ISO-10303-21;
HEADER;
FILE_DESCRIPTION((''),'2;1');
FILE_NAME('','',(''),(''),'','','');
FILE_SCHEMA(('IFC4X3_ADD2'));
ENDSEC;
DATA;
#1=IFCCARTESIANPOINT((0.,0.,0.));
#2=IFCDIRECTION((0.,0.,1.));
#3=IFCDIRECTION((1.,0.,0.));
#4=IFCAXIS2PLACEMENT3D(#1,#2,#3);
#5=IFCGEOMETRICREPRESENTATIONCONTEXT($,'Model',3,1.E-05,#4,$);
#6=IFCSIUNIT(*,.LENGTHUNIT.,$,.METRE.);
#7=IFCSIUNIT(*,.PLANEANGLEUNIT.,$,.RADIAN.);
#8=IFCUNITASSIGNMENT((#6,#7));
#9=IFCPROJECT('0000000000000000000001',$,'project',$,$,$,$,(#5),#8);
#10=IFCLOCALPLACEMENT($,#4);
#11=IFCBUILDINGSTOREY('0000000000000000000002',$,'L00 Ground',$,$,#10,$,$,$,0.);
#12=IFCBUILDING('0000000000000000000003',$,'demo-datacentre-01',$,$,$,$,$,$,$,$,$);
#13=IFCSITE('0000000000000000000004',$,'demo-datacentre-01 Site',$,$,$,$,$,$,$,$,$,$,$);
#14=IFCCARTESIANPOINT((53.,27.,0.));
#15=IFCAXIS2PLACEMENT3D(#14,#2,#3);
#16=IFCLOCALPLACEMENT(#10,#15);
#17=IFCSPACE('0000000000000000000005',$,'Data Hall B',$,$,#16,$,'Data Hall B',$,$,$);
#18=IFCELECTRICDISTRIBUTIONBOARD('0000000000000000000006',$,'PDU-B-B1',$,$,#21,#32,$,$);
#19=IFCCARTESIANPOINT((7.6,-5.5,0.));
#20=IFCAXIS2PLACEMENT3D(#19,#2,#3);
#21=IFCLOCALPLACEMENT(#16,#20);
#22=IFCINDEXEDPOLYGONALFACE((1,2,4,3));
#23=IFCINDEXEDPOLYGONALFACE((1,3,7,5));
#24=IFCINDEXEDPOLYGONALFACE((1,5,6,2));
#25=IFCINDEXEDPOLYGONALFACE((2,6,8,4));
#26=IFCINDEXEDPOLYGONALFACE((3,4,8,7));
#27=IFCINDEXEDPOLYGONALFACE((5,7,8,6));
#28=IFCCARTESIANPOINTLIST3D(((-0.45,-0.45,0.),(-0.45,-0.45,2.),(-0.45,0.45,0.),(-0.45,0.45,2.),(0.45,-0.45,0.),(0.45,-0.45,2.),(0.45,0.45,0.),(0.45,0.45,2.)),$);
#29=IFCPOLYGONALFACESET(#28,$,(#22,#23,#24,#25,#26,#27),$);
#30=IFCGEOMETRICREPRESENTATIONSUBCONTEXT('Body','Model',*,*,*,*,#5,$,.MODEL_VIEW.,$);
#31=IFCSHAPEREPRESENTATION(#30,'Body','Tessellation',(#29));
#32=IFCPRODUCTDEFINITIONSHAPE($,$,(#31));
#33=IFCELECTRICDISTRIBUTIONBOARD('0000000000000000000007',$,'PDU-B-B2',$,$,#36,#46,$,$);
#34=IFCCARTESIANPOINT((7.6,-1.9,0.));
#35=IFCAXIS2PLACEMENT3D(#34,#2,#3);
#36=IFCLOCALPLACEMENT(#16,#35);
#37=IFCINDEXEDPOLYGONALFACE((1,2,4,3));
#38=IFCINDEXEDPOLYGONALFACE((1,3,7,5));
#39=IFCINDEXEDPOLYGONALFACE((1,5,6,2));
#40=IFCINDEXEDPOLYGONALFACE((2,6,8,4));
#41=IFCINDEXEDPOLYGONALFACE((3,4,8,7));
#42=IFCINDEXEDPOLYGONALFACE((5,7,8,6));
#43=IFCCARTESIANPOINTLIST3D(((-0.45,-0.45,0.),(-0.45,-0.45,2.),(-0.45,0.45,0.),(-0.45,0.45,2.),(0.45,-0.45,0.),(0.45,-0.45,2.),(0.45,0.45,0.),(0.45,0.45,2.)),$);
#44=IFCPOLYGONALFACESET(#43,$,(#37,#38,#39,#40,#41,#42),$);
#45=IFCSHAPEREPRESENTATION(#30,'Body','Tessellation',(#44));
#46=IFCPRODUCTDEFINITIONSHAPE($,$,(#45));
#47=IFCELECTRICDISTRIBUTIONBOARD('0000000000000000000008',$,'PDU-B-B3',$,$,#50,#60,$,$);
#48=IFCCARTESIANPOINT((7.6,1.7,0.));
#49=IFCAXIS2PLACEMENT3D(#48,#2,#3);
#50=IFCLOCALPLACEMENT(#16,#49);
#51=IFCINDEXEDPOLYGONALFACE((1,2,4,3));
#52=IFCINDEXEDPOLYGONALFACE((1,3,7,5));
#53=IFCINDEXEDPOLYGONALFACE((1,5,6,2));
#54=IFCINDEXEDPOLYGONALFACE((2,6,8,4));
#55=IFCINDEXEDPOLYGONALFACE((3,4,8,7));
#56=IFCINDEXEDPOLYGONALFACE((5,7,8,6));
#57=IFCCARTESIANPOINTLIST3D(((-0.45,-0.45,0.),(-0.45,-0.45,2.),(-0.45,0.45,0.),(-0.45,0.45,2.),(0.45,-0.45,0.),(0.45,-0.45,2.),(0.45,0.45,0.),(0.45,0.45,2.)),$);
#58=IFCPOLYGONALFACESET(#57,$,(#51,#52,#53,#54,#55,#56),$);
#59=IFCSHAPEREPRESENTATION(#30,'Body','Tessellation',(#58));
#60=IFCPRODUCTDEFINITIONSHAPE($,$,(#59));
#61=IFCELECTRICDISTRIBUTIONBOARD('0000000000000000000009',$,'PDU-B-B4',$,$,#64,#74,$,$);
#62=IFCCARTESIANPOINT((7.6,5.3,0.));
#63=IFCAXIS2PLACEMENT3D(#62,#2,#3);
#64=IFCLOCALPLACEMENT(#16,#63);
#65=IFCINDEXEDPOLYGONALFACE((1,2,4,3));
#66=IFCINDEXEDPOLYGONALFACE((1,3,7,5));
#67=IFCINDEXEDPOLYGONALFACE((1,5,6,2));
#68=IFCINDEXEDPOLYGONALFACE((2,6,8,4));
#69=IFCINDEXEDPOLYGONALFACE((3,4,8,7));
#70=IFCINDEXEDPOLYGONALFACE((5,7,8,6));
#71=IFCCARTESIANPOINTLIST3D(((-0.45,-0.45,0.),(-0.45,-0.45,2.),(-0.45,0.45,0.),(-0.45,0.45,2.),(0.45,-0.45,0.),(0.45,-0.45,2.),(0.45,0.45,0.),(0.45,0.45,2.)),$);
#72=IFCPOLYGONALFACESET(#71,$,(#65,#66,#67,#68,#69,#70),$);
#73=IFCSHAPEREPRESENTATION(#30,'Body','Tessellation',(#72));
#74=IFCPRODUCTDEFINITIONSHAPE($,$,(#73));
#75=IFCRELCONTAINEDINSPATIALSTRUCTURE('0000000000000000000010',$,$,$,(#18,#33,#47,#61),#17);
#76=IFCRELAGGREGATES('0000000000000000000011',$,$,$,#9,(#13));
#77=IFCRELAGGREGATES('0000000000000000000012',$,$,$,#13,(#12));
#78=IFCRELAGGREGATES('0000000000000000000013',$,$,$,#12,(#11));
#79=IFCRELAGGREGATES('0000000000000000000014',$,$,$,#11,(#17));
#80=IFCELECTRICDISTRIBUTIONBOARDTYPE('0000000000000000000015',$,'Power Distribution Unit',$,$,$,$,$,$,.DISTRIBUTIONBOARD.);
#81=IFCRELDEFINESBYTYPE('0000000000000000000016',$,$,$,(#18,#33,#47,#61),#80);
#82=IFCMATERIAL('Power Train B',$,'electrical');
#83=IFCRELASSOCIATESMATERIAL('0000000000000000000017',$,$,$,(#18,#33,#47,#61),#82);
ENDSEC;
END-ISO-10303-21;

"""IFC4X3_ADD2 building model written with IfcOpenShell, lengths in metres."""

from ifc_helpers import new_model, si_unit, frame, origin_with_axes, place, context, subcontext, project, spatial, rectangle, extrude, material, type_object, element, save


model = new_model("IFC4X3_ADD2")

# Units and contexts
model_context = context("Model", 3, precision=1e-05, world=origin_with_axes())
body_context = subcontext(model_context, "Body", "Model", "MODEL_VIEW")
ifc_project = project(units=[si_unit("LENGTHUNIT", "METRE"), si_unit("PLANEANGLEUNIT", "RADIAN")], contexts=[model_context])

# Site, building, storey, space
site = spatial("IfcSite", under=ifc_project, Name="demo-datacentre-01 Site")
building = spatial("IfcBuilding", under=site, Name="demo-datacentre-01")
storey_placement = place(None, origin_with_axes())
storey = spatial("IfcBuildingStorey", under=building, at=storey_placement, Name="L00 Ground", Elevation=0.0)
space_1_placement = place(storey_placement, frame((53.0, 27.0, 0.0), z_axis=(0.0, 0.0, 1.0), x_axis=(1.0, 0.0, 0.0)))
space_1 = spatial("IfcSpace", under=storey, at=space_1_placement, Name="Data Hall B", LongName="Data Hall B")

# Electric distribution boards
ifc_material = material(Name="Power Train B", Category="electrical")
electric_distribution_board_type_1 = type_object("IfcElectricDistributionBoardType", Name="Power Distribution Unit", PredefinedType="DISTRIBUTIONBOARD")
for number, where, z_axis, x_axis, name in (
    (1, (7.6, -5.5, 0.0), (0.0, 0.0, 1.0), (1.0, 0.0, 0.0), "PDU-B-B1"),
    (2, (7.6, -1.9, 0.0), (0.0, 0.0, 1.0), (1.0, 0.0, 0.0), "PDU-B-B2"),
    (3, (7.6, 1.7, 0.0), (0.0, 0.0, 1.0), (1.0, 0.0, 0.0), "PDU-B-B3"),
    (4, (7.6, 5.3, 0.0), (0.0, 0.0, 1.0), (1.0, 0.0, 0.0), "PDU-B-B4"),
):
    element("IfcElectricDistributionBoard", number, at=place(space_1_placement, frame(where, z_axis=z_axis, x_axis=x_axis)), inside=space_1, type_object=electric_distribution_board_type_1, material=ifc_material, Name=name, context=body_context, shape_type="SweptSolid", body=[
        extrude(rectangle(XDim=0.9, YDim=0.9), origin_with_axes(), (0.0, 0.0, 1.0), 2.0),
    ])

save(model, "model.ifc")
